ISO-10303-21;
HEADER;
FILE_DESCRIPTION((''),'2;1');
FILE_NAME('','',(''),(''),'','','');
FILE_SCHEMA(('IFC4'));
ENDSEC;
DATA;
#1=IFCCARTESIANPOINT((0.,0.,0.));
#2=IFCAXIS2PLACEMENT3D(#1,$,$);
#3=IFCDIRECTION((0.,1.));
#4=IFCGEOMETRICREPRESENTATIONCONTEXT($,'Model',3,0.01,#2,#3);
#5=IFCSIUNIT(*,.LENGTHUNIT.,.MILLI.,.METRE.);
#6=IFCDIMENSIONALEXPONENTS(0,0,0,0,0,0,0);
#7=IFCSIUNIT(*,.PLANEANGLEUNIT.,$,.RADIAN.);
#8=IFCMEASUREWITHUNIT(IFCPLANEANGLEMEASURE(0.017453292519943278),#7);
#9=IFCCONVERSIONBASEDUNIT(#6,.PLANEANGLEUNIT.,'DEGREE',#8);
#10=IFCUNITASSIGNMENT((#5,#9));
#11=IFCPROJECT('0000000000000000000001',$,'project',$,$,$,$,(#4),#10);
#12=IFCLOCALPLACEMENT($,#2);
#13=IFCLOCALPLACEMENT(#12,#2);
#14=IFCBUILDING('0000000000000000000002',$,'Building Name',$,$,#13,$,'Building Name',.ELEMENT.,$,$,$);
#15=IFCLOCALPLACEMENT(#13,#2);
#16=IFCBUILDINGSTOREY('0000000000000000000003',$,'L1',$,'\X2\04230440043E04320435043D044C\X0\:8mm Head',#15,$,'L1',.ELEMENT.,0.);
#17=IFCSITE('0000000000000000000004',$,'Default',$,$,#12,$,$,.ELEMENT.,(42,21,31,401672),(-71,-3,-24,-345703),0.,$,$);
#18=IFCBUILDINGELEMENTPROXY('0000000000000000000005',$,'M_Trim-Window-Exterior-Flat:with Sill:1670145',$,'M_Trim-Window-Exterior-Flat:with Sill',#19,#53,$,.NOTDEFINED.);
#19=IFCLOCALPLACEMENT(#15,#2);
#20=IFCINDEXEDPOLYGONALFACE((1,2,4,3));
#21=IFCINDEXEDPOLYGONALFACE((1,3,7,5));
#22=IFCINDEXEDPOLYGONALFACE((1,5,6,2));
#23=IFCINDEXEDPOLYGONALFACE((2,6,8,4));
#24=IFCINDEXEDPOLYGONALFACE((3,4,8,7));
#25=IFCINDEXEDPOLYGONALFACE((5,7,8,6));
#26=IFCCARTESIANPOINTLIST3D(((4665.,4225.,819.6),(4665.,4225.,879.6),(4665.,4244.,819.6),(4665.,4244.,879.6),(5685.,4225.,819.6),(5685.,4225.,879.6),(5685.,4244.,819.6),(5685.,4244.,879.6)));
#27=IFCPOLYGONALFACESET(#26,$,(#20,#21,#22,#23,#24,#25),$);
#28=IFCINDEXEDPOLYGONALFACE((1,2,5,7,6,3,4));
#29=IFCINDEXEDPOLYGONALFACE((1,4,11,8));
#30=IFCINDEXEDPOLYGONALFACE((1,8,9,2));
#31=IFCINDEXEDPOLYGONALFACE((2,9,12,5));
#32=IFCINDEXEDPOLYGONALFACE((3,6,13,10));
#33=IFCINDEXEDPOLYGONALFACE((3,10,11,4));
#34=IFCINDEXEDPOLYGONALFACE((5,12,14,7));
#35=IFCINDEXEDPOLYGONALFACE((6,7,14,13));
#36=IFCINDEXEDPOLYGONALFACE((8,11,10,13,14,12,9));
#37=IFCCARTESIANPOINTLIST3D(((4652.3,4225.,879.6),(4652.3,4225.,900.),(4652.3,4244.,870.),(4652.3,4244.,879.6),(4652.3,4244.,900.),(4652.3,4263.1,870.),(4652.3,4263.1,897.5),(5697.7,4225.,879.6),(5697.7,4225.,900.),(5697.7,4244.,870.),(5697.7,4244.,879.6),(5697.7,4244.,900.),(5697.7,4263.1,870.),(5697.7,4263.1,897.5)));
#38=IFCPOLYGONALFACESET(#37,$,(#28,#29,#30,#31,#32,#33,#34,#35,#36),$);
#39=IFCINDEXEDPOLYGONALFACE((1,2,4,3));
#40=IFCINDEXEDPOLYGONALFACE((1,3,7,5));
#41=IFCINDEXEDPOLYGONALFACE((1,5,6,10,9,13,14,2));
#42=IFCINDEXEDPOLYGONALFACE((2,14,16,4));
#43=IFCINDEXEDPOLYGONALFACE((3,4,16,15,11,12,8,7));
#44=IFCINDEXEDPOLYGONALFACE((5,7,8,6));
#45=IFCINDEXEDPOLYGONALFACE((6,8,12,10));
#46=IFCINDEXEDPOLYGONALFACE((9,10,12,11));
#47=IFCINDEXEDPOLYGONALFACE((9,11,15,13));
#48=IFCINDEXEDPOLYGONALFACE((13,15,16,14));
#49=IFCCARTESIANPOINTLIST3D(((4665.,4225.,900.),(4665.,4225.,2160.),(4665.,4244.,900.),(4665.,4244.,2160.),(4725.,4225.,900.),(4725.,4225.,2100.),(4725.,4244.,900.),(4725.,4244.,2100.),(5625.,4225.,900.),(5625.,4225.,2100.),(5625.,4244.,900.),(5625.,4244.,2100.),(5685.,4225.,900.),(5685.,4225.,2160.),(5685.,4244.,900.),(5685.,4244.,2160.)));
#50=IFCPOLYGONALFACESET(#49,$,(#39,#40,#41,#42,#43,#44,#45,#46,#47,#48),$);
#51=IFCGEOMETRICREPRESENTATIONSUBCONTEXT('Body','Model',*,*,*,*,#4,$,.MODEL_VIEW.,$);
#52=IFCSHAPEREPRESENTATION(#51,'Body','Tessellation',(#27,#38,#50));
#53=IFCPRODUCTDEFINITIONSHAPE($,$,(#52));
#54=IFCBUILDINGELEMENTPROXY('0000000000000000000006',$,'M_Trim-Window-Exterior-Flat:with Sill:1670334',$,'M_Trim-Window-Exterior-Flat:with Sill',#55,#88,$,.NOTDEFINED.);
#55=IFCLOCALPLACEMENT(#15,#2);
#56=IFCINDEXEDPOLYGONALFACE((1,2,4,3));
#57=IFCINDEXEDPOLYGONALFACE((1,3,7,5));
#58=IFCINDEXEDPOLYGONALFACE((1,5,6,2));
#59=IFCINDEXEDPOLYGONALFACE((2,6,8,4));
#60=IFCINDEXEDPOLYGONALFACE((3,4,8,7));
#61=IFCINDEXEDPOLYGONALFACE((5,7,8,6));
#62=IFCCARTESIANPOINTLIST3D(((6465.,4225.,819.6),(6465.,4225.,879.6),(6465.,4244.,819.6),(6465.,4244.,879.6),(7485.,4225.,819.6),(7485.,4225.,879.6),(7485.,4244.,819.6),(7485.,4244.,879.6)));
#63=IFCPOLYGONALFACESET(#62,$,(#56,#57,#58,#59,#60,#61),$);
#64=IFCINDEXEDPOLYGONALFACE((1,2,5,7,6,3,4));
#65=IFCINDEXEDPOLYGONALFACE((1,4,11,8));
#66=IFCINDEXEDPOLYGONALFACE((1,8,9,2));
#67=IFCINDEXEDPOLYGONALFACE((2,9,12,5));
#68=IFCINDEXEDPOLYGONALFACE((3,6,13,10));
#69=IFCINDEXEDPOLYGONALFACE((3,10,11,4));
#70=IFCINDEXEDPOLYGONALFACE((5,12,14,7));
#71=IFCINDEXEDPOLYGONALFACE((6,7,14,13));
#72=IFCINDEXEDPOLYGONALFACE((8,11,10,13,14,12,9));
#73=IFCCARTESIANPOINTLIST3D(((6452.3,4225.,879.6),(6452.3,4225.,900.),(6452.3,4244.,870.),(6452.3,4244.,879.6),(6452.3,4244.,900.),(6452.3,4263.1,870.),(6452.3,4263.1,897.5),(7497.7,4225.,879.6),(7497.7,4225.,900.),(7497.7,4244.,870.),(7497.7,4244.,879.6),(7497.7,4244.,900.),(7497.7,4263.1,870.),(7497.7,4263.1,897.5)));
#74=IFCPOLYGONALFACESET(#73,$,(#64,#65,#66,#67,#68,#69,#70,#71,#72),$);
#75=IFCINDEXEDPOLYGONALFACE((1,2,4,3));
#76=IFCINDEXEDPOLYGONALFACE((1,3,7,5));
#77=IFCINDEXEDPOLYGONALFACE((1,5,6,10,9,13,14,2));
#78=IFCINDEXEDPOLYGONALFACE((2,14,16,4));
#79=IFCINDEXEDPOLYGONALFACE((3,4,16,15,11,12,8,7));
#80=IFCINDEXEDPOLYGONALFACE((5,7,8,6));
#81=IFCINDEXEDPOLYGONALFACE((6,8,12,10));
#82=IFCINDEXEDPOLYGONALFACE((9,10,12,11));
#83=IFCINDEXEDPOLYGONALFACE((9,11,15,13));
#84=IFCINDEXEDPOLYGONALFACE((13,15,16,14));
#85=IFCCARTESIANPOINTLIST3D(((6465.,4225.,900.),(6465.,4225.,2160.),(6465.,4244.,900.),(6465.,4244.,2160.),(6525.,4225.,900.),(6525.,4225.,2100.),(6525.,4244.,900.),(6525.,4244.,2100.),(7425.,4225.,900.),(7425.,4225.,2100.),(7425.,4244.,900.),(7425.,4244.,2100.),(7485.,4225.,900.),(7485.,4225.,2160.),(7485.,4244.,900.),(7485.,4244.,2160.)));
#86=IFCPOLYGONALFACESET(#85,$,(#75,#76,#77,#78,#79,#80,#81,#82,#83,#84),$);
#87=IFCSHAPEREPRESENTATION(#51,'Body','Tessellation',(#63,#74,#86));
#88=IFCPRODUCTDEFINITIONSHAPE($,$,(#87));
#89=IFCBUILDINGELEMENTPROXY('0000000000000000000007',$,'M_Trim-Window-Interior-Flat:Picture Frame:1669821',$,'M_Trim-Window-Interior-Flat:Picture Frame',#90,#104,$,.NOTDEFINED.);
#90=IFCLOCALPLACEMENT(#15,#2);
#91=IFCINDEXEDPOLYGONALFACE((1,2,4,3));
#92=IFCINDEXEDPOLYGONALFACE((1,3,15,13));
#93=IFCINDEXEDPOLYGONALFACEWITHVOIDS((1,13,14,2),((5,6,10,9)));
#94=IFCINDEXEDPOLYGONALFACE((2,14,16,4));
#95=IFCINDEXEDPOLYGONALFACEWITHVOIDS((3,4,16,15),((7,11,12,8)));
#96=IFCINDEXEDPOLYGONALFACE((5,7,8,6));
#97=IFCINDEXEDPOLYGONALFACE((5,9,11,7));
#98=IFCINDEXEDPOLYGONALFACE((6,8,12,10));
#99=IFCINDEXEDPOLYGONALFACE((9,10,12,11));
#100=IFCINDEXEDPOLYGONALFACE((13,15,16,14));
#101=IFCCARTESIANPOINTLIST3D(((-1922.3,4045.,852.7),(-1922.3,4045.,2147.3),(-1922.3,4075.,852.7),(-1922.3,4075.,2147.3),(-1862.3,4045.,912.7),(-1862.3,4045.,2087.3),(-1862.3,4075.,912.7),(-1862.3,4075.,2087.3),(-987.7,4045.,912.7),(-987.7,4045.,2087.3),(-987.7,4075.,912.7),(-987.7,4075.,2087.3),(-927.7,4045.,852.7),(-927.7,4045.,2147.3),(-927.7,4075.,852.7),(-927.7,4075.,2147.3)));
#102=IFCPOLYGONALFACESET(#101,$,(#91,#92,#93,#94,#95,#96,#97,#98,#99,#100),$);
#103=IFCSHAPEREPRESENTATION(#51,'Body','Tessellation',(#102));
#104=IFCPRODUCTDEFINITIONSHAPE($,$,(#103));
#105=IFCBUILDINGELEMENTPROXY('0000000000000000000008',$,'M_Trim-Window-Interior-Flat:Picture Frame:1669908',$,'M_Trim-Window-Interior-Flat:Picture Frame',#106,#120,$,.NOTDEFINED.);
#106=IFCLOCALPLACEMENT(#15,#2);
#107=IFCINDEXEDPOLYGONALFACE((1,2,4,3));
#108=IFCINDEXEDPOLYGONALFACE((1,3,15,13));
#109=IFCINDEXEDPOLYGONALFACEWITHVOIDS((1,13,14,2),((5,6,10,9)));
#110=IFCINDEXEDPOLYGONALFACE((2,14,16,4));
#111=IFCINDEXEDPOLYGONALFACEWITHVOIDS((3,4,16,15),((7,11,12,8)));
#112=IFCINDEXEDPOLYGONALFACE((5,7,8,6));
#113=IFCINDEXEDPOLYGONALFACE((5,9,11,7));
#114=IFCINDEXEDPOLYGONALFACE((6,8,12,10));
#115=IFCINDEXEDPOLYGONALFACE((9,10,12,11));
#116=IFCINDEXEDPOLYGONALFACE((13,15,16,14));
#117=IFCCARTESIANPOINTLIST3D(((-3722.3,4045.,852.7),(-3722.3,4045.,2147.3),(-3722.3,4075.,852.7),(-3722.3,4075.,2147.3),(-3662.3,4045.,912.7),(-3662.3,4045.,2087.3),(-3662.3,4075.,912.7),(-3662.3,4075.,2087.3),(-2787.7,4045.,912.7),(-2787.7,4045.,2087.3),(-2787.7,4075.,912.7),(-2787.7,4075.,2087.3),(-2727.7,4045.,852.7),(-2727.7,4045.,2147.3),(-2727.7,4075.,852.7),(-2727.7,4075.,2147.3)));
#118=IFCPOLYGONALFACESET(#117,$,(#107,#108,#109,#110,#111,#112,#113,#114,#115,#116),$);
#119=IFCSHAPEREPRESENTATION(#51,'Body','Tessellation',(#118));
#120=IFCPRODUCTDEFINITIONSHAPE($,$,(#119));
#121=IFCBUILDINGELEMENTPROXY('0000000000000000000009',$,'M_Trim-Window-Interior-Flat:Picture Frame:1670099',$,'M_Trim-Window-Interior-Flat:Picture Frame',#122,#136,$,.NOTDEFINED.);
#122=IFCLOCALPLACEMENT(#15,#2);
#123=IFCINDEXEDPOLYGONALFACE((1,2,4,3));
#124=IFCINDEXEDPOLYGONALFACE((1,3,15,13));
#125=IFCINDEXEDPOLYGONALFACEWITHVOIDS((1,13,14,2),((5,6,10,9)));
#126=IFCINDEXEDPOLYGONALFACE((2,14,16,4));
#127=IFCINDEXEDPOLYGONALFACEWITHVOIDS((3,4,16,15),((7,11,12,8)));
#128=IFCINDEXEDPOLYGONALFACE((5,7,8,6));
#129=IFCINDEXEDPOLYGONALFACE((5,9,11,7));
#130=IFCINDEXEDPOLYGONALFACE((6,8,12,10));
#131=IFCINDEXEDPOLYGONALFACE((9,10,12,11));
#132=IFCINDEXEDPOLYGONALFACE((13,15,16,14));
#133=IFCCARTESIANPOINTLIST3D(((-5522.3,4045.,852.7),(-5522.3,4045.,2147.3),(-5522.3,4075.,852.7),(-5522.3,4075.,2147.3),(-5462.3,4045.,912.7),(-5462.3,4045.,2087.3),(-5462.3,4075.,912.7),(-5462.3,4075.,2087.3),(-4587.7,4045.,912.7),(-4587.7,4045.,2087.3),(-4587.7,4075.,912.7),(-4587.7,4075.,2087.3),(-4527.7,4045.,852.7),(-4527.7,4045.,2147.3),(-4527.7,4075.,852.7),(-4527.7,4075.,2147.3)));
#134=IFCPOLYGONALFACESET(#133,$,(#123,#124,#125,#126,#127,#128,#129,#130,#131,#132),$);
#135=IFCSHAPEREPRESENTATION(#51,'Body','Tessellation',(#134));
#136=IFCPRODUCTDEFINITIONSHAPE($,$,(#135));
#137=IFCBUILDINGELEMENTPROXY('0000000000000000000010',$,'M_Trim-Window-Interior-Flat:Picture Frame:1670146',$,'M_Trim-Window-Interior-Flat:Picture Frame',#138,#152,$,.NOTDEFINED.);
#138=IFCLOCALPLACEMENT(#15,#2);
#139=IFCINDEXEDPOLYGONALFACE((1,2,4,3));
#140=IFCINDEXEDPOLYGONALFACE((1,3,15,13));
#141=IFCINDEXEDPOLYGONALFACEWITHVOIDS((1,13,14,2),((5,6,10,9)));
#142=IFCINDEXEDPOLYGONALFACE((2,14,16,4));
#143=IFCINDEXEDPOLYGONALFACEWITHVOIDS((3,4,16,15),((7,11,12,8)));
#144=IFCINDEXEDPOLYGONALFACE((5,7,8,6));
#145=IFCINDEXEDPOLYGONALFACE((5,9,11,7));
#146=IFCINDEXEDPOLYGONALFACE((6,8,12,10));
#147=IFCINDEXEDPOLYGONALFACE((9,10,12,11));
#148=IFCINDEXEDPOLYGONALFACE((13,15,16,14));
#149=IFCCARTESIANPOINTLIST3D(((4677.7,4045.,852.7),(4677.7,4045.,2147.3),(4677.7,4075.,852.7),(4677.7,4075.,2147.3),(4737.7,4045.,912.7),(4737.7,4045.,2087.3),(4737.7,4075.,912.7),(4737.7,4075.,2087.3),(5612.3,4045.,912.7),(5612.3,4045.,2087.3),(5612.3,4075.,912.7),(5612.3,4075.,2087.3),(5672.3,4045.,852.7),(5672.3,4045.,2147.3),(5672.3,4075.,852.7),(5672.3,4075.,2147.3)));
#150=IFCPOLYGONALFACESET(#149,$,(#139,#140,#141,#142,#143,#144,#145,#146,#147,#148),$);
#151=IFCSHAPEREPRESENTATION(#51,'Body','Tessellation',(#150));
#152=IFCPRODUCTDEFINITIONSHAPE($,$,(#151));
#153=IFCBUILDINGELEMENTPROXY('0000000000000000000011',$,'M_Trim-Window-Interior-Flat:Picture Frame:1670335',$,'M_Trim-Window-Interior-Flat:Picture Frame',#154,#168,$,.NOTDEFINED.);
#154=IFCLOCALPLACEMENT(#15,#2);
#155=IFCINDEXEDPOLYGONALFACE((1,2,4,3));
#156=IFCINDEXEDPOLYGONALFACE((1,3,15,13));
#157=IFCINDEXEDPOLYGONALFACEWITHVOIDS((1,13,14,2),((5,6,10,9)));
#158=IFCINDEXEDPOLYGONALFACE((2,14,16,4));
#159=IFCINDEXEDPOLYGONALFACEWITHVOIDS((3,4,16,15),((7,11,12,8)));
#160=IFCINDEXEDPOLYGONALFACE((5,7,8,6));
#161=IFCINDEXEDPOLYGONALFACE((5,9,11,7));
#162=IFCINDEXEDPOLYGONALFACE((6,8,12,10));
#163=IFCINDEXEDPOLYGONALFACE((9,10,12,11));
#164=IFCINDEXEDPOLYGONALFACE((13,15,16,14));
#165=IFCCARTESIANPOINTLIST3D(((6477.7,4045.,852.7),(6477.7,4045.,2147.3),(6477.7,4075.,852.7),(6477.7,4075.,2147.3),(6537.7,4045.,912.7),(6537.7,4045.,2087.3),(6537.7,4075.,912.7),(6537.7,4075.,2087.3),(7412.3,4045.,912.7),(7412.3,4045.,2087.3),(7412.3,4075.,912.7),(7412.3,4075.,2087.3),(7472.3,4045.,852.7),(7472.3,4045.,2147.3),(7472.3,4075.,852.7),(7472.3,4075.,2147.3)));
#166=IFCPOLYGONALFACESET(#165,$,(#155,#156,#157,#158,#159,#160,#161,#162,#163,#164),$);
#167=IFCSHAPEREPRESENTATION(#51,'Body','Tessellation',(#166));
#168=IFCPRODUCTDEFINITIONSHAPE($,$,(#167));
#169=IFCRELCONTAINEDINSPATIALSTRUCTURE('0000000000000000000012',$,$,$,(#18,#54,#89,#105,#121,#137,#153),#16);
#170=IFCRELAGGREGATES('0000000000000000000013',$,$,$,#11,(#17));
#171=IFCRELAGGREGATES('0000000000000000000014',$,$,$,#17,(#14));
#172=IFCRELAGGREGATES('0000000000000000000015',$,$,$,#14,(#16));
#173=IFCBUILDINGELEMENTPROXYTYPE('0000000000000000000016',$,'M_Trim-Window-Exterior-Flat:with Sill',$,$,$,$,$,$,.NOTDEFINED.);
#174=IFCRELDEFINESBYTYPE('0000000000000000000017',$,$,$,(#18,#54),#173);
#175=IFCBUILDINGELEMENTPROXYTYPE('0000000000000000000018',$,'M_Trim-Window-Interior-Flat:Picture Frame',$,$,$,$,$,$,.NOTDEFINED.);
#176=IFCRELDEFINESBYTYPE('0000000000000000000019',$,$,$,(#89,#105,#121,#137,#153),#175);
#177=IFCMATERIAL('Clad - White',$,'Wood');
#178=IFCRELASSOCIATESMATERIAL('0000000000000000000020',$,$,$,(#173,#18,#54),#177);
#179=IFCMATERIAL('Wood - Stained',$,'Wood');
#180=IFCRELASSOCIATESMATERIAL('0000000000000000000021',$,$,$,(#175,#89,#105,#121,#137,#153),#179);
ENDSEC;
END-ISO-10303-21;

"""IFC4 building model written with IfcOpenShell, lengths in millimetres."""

from ifc_helpers import new_model, entity, si_unit, converted_unit, direction, frame, frame_2d, origin, place, context, subcontext, project, spatial, polyline, rectangle, outline, extrude, source, transform, mapped, material, type_object, type_shapes, element, save


model = new_model("IFC4")

# Units and contexts
model_context = context("Model", 3, precision=0.01, world=origin(), true_north=direction((0.0, 1.0)))
body_context = subcontext(model_context, "Body", "Model", "MODEL_VIEW")
ifc_project = project(units=[si_unit("LENGTHUNIT", "METRE", prefix="MILLI"), converted_unit("PLANEANGLEUNIT", "DEGREE", entity("IfcPlaneAngleMeasure", 0.017453292519943278), si_unit("PLANEANGLEUNIT", "RADIAN"), dimensions=[0, 0, 0, 0, 0, 0, 0])], contexts=[model_context])

# Site, building, storey
site_placement = place(None, origin())
site = spatial("IfcSite", under=ifc_project, at=site_placement, Name="Default", CompositionType="ELEMENT", RefLatitude=(42, 21, 31, 401672), RefLongitude=(-71, -3, -24, -345703), RefElevation=0.0)
building_placement = place(site_placement, origin())
building = spatial("IfcBuilding", under=site, at=building_placement, Name="Building Name", LongName="Building Name", CompositionType="ELEMENT")
storey_placement = place(building_placement, origin())
storey = spatial("IfcBuildingStorey", under=building, at=storey_placement, Name="L1", ObjectType="Уровень:8mm Head", LongName="L1", CompositionType="ELEMENT", Elevation=0.0)

# Building element proxies
ifc_material_1 = material(Name="Clad - White", Category="Wood")
ifc_material_2 = material(Name="Wood - Stained", Category="Wood")
building_element_proxy_type_1 = type_object("IfcBuildingElementProxyType", Name="M_Trim-Window-Exterior-Flat:with Sill", PredefinedType="NOTDEFINED", material=ifc_material_1)
shared_shape_1 = source(origin(), body_context, "Body", "SweptSolid", [
    extrude(rectangle(XDim=1020.0, YDim=60.0, at=frame_2d((0.0, 0.0), x_axis=(1.0, 0.0))), frame((0.0, -1250.4, 0.0), z_axis=(0.0, 0.0, 1.0), x_axis=(-1.0, 0.0, 0.0)), (0.0, 0.0, 1.0), 19.0),
    extrude(outline(polyline([(-19.0, -15.2), (0.0, -15.2), (0.0, -5.7), (19.0, -5.7), (19.0, 14.8), (0.0, 14.8), (-19.0, 12.3), (-19.0, -15.2)])), frame((-522.7, -1214.8, 19.0), z_axis=(1.0, 0.0, 0.0), x_axis=(0.0, 0.0, -1.0)), (0.0, 0.0, 1.0), 1045.4),
    extrude(outline(polyline([(-645.0, -510.0), (615.0, -510.0), (615.0, -450.0), (-585.0, -450.0), (-585.0, 450.0), (615.0, 450.0), (615.0, 510.0), (-645.0, 510.0), (-645.0, -510.0)])), frame((0.0, -585.0, 0.0), z_axis=(0.0, 0.0, 1.0), x_axis=(0.0, -1.0, 0.0)), (0.0, 0.0, 1.0), 19.0),
])
type_shapes(building_element_proxy_type_1, [shared_shape_1])
for number, where, z_axis, x_axis, name in (
    (1, (5175.0, 4225.0, 2100.0), (0.0, 1.0, 0.0), (-1.0, 0.0, 0.0), "M_Trim-Window-Exterior-Flat:with Sill:1670145"),
    (2, (6975.0, 4225.0, 2100.0), (0.0, 1.0, 0.0), (-1.0, 0.0, 0.0), "M_Trim-Window-Exterior-Flat:with Sill:1670334"),
):
    element("IfcBuildingElementProxy", number, at=place(storey_placement, frame(where, z_axis=z_axis, x_axis=x_axis)), inside=storey, type_object=building_element_proxy_type_1, material=ifc_material_1, Name=name, ObjectType="M_Trim-Window-Exterior-Flat:with Sill", PredefinedType="NOTDEFINED", context=body_context, shape_type="MappedRepresentation", body=[
        mapped(shared_shape_1, transform((0.0, 0.0, 0.0), scale=1.0)),
    ])
building_element_proxy_type_2 = type_object("IfcBuildingElementProxyType", Name="M_Trim-Window-Interior-Flat:Picture Frame", PredefinedType="NOTDEFINED", material=ifc_material_2)
shared_shape_2 = source(origin(), body_context, "Body", "SweptSolid", [
    extrude(outline(polyline([(-497.3, -647.3), (497.3, -647.3), (497.3, 647.3), (-497.3, 647.3), (-497.3, -647.3)]), holes=[polyline([(-437.3, -587.3), (-437.3, 587.3), (437.3, 587.3), (437.3, -587.3), (-437.3, -587.3)])]), frame((0.0, -600.0, 0.0), z_axis=(0.0, 0.0, 1.0), x_axis=(-1.0, 0.0, 0.0)), (0.0, 0.0, 1.0), 30.0),
])
type_shapes(building_element_proxy_type_2, [shared_shape_2])
for number, where, z_axis, x_axis, name in (
    (3, (-1425.0, 4075.0, 2100.0), (0.0, -1.0, 0.0), (1.0, 0.0, 0.0), "M_Trim-Window-Interior-Flat:Picture Frame:1669821"),
    (4, (-3225.0, 4075.0, 2100.0), (0.0, -1.0, 0.0), (1.0, 0.0, 0.0), "M_Trim-Window-Interior-Flat:Picture Frame:1669908"),
    (5, (-5025.0, 4075.0, 2100.0), (0.0, -1.0, 0.0), (1.0, 0.0, 0.0), "M_Trim-Window-Interior-Flat:Picture Frame:1670099"),
    (6, (5175.0, 4075.0, 2100.0), (0.0, -1.0, 0.0), (1.0, 0.0, 0.0), "M_Trim-Window-Interior-Flat:Picture Frame:1670146"),
    (7, (6975.0, 4075.0, 2100.0), (0.0, -1.0, 0.0), (1.0, 0.0, 0.0), "M_Trim-Window-Interior-Flat:Picture Frame:1670335"),
):
    element("IfcBuildingElementProxy", number, at=place(storey_placement, frame(where, z_axis=z_axis, x_axis=x_axis)), inside=storey, type_object=building_element_proxy_type_2, material=ifc_material_2, Name=name, ObjectType="M_Trim-Window-Interior-Flat:Picture Frame", PredefinedType="NOTDEFINED", context=body_context, shape_type="MappedRepresentation", body=[
        mapped(shared_shape_2, transform((0.0, 0.0, 0.0), scale=1.0)),
    ])

save(model, "model.ifc")
